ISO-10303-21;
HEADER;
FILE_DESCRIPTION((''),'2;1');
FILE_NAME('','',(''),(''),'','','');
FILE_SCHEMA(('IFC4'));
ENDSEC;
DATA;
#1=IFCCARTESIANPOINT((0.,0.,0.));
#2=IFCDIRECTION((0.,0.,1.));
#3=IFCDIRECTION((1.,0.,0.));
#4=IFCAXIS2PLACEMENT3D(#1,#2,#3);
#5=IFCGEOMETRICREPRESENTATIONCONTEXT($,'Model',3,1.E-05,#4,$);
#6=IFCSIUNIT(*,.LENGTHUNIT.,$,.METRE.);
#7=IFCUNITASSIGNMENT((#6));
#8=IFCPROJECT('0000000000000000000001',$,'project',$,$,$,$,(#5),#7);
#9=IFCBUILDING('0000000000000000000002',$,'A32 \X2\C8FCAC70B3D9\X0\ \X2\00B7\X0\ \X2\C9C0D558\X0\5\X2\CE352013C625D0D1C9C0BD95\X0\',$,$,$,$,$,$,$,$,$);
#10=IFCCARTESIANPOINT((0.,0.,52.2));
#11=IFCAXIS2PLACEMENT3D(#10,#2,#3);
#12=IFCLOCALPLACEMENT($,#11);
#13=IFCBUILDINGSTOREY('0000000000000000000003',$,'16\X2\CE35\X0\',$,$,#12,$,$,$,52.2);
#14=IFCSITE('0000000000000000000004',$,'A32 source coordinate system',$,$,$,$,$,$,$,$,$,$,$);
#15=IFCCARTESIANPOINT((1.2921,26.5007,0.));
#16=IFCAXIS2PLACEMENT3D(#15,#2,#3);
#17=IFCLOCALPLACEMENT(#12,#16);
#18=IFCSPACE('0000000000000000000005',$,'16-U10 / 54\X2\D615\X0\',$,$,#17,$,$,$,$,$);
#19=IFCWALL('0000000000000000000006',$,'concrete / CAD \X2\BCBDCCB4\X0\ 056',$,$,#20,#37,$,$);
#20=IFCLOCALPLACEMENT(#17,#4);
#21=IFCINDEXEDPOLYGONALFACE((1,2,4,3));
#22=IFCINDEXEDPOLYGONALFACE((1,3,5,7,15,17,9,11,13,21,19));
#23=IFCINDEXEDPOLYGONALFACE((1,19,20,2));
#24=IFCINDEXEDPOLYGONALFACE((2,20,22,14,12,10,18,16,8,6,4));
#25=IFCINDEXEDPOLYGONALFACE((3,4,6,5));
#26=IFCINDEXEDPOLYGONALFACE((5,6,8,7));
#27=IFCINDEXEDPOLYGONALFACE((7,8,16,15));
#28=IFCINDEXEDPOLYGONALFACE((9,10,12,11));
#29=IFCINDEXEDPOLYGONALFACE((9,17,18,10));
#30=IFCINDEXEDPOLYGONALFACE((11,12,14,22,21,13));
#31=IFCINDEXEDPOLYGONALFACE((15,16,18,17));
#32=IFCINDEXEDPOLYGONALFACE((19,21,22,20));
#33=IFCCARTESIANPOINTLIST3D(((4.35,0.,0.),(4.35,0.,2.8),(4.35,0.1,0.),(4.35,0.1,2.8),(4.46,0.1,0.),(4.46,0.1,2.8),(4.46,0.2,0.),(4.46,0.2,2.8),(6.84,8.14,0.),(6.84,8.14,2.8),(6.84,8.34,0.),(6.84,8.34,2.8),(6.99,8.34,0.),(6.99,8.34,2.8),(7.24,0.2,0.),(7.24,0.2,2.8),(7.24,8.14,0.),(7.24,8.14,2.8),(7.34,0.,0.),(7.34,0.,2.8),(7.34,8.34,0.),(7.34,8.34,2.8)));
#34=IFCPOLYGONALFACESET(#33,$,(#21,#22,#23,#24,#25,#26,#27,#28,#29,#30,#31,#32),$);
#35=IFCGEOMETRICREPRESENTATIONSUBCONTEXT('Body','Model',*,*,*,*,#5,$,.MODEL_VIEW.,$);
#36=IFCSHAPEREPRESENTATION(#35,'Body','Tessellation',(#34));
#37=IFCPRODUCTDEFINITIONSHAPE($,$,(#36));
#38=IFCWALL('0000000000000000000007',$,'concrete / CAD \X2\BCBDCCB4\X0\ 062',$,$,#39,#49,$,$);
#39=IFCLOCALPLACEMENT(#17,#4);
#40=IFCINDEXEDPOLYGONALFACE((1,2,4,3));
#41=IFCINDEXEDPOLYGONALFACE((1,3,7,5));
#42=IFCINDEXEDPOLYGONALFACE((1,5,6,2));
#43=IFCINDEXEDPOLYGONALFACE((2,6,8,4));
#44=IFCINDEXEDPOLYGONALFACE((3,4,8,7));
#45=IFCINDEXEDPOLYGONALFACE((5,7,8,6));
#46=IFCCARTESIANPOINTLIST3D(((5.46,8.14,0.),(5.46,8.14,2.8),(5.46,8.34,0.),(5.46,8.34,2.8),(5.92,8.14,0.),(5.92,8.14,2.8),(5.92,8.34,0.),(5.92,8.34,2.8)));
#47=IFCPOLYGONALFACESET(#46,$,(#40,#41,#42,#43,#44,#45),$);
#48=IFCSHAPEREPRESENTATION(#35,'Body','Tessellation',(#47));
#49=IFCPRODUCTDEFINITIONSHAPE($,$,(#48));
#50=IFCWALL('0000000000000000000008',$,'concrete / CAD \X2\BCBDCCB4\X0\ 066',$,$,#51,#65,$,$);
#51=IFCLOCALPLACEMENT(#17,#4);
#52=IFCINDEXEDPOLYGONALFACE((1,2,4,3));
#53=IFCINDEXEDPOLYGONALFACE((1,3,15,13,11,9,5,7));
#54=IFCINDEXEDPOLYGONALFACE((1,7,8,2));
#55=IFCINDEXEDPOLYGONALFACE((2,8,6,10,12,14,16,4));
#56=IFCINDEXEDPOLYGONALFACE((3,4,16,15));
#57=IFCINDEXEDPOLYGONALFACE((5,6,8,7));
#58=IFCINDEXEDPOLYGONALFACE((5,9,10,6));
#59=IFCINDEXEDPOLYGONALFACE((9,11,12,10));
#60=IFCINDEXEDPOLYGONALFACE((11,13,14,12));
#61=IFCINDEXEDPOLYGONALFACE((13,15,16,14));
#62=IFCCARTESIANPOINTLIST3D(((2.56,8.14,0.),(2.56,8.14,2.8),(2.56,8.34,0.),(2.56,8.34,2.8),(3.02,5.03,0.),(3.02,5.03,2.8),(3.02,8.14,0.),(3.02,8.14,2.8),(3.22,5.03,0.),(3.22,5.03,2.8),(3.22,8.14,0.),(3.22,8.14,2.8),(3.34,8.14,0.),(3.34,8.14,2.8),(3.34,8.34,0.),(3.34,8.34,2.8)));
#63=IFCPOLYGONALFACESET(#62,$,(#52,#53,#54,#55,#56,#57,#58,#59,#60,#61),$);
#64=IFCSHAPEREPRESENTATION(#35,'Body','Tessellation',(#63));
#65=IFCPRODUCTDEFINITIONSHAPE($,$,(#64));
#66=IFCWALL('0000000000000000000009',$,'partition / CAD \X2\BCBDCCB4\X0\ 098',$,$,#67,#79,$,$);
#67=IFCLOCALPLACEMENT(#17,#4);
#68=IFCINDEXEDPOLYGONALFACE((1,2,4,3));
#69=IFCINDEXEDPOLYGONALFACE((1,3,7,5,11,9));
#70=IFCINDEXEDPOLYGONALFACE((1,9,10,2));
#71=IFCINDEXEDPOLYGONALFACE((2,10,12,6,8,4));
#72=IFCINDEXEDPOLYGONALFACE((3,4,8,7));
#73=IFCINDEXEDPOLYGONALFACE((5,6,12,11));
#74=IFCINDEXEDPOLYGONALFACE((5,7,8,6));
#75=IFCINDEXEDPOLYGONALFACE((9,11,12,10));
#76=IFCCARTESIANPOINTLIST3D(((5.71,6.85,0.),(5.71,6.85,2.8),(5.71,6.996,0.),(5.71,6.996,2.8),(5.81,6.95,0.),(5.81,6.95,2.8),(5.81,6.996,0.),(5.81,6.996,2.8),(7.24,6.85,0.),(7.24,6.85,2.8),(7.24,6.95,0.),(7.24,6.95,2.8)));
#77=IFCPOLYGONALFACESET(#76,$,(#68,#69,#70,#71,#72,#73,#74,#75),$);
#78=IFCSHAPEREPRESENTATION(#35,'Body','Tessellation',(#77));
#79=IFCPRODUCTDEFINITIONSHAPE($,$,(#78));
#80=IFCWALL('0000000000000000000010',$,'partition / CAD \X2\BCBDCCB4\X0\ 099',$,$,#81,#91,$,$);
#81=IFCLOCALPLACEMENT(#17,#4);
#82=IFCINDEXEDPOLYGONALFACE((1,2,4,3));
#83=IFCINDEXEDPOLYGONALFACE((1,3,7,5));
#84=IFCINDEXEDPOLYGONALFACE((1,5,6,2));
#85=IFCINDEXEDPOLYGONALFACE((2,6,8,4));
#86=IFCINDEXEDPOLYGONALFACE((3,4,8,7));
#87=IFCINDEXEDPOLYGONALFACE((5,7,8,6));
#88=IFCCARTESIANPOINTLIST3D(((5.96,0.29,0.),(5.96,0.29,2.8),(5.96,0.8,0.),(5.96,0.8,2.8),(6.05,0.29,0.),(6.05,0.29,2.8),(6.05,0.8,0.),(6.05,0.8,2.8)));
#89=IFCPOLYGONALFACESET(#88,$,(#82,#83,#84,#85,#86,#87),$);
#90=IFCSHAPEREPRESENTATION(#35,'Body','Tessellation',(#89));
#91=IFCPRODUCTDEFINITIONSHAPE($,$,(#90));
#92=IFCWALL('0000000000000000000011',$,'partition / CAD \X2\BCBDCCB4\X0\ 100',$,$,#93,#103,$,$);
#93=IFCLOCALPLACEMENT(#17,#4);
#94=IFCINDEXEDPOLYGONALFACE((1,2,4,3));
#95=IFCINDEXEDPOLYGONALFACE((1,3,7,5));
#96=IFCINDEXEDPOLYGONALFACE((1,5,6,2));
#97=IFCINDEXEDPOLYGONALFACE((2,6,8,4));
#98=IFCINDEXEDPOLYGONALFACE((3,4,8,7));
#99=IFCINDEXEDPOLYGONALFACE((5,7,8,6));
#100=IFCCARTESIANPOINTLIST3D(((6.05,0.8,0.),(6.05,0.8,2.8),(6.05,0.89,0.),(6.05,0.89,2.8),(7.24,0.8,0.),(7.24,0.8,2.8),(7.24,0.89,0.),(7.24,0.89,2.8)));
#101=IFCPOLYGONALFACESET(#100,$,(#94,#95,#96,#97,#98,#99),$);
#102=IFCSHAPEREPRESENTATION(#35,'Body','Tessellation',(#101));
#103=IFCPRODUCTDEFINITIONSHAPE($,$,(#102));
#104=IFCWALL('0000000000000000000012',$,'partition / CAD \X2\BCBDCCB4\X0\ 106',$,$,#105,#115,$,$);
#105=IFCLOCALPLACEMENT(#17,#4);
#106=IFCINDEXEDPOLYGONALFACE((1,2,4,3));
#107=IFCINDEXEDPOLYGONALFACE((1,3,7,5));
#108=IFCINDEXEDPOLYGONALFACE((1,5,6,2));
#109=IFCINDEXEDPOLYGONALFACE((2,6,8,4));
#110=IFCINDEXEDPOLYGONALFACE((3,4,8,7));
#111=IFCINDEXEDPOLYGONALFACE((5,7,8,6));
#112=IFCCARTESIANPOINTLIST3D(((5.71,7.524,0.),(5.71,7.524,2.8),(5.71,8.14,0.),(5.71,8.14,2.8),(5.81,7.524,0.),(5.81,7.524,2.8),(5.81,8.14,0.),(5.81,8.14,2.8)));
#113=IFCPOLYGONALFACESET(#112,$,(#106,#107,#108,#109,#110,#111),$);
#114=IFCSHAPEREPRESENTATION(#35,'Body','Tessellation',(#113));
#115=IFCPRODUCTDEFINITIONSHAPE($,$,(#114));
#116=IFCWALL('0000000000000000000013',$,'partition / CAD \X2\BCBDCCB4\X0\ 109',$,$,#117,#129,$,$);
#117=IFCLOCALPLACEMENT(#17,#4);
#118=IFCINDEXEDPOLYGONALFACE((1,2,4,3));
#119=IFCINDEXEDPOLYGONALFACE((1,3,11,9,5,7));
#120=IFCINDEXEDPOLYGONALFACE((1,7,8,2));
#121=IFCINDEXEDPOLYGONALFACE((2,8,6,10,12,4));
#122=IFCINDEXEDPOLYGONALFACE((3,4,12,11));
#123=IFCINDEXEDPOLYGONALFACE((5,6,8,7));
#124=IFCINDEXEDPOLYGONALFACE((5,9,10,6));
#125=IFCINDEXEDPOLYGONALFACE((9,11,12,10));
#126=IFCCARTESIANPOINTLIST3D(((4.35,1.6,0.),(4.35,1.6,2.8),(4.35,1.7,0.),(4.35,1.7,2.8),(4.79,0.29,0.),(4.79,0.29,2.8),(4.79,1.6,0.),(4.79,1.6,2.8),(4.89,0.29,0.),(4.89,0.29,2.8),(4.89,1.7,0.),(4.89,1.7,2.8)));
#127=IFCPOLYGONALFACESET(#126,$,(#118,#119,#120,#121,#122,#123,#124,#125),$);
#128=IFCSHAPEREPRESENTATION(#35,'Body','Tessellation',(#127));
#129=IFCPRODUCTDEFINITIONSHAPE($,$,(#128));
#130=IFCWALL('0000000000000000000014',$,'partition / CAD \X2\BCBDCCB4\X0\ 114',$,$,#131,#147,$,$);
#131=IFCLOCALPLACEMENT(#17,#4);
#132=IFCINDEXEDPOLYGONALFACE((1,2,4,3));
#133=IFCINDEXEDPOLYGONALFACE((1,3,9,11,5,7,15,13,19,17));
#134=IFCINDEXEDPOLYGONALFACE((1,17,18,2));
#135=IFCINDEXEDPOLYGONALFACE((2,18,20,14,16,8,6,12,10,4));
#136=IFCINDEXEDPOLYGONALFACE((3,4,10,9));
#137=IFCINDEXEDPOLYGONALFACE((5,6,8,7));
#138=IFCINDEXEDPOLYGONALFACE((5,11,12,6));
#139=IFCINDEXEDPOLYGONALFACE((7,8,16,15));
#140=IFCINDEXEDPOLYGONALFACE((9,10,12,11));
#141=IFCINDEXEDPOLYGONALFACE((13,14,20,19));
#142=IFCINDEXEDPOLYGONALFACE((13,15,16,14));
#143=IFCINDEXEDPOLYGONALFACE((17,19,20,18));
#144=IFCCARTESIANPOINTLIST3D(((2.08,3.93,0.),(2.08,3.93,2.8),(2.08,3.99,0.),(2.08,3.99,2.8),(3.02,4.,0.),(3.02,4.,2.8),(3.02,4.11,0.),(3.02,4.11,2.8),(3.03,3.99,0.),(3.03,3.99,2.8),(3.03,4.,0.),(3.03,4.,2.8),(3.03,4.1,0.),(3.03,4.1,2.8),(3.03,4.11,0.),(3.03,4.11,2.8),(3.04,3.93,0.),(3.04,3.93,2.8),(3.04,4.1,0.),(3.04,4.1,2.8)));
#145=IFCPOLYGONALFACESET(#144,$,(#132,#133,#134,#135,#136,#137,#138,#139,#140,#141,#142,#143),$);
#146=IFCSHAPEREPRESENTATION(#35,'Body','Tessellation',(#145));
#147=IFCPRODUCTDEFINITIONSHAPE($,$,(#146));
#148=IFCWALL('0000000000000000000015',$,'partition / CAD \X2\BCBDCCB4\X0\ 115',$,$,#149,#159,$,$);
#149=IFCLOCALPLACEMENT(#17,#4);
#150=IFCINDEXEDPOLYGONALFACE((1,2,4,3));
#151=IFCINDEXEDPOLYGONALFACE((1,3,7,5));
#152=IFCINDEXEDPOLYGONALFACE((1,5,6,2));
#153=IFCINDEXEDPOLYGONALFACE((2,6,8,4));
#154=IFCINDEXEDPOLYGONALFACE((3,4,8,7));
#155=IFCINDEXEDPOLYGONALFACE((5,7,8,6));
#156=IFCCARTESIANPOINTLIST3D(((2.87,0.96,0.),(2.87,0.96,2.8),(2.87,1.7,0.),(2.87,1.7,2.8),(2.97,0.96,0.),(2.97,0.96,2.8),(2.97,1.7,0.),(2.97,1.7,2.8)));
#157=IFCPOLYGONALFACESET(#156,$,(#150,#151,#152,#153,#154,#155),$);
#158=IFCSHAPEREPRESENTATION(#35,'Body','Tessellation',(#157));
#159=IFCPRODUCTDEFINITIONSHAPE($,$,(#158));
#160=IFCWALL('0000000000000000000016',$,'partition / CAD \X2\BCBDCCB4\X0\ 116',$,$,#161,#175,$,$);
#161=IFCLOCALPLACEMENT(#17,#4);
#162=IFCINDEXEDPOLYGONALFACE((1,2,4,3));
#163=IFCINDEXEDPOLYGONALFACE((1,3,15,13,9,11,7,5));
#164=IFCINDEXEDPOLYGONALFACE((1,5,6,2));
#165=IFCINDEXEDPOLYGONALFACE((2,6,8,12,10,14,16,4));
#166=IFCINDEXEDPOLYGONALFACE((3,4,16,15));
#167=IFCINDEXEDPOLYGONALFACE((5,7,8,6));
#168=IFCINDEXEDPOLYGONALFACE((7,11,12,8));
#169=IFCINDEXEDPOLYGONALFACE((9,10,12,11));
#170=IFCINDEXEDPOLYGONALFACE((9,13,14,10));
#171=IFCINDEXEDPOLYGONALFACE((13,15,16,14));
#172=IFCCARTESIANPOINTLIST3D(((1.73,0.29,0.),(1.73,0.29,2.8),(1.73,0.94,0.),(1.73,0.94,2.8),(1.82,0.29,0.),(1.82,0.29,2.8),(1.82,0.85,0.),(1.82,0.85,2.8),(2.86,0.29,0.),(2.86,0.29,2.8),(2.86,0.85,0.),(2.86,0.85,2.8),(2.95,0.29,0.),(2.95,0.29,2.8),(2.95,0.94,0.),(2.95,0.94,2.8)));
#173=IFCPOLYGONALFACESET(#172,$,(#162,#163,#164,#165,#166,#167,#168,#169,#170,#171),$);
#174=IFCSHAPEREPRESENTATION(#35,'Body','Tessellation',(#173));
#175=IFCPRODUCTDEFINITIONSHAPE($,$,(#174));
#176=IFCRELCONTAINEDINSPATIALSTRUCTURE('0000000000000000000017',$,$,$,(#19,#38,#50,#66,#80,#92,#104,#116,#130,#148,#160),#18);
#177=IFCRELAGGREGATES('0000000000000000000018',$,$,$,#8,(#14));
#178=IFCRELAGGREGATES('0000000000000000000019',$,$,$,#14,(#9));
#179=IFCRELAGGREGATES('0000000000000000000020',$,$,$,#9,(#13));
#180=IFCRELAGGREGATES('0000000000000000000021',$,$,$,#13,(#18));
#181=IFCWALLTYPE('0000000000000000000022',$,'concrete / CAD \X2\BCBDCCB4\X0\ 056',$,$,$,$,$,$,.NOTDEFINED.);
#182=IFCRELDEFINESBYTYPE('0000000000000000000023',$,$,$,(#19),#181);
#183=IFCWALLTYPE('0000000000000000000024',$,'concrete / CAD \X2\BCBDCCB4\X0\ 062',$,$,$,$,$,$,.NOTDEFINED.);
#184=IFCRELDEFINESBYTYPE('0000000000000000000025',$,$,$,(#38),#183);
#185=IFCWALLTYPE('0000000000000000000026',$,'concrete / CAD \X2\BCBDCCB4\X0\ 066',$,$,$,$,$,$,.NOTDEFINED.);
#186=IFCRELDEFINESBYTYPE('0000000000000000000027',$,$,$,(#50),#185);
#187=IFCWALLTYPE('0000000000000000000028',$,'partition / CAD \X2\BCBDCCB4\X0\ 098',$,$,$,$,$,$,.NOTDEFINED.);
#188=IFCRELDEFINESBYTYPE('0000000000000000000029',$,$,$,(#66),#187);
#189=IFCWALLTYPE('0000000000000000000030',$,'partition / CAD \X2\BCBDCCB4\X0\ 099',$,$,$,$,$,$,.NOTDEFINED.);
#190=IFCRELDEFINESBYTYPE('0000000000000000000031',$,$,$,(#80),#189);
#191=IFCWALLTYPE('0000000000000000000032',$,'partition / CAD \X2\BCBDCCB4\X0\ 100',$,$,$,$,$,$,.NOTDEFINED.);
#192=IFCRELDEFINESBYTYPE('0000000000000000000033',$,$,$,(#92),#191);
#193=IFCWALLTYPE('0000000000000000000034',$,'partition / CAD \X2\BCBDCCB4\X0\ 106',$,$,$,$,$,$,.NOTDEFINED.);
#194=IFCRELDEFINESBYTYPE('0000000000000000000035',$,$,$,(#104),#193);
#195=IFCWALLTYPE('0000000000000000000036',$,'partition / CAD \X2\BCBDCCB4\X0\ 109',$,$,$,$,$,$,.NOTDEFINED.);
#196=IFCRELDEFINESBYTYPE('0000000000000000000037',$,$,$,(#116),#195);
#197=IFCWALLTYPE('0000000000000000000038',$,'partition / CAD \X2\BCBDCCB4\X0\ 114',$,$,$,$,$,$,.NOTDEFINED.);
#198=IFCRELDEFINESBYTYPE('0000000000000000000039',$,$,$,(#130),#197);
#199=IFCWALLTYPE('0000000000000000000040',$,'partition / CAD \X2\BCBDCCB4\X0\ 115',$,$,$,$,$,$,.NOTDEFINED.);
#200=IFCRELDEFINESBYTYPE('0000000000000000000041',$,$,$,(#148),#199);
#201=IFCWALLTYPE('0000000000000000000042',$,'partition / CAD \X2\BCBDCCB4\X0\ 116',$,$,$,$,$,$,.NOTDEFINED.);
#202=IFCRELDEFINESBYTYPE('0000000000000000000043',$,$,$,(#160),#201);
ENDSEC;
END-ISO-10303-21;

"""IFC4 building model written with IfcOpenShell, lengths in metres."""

from ifc_helpers import new_model, si_unit, frame, origin, origin_with_axes, place, context, subcontext, project, spatial, polyline, outline, extrude, source, transform, mapped, type_object, type_shapes, element, save


model = new_model("IFC4")

# Units and contexts
model_context = context("Model", 3, precision=1e-05, world=origin_with_axes())
body_context = subcontext(model_context, "Body", "Model", "MODEL_VIEW")
ifc_project = project(units=[si_unit("LENGTHUNIT", "METRE")], contexts=[model_context])

# Site, building, storey, space
site = spatial("IfcSite", under=ifc_project, Name="A32 source coordinate system")
building = spatial("IfcBuilding", under=site, Name="A32 주거동 · 지하5층–옥탑지붕")
storey_placement = place(None, frame((0.0, 0.0, 52.2), z_axis=(0.0, 0.0, 1.0), x_axis=(1.0, 0.0, 0.0)))
storey = spatial("IfcBuildingStorey", under=building, at=storey_placement, Name="16층", Elevation=52.2)
space_placement = place(storey_placement, frame((1.2921, 26.5007, 0.0), z_axis=(0.0, 0.0, 1.0), x_axis=(1.0, 0.0, 0.0)))
space = spatial("IfcSpace", under=storey, at=space_placement, Name="16-U10 / 54형")

# Walls
wall_type_1 = type_object("IfcWallType", Name="concrete / CAD 벽체 056", PredefinedType="NOTDEFINED")
shared_shape_1 = source(origin(), body_context, "Body", "SweptSolid", [
    extrude(outline(polyline([(7.24, 0.2), (7.24, 8.14), (6.84, 8.14), (6.84, 8.34), (6.99, 8.34), (6.99, 8.34), (7.34, 8.34), (7.34, 0.0), (4.35, 0.0), (4.35, 0.1), (4.46, 0.1), (4.46, 0.2), (7.24, 0.2)])), origin(), (0.0, 0.0, 1.0), 2.8),
])
type_shapes(wall_type_1, [shared_shape_1])
wall_1_placement = place(space_placement, origin_with_axes())
element("IfcWall", 1, at=wall_1_placement, inside=space, type_object=wall_type_1, Name="concrete / CAD 벽체 056", context=body_context, shape_type="MappedRepresentation", body=[
    mapped(shared_shape_1, transform((0.0, 0.0, 0.0), scale=1.0)),
])
wall_type_2 = type_object("IfcWallType", Name="concrete / CAD 벽체 062", PredefinedType="NOTDEFINED")
shared_shape_2 = source(origin(), body_context, "Body", "SweptSolid", [
    extrude(outline(polyline([(5.46, 8.14), (5.46, 8.34), (5.92, 8.34), (5.92, 8.14), (5.46, 8.14)])), origin(), (0.0, 0.0, 1.0), 2.8),
])
type_shapes(wall_type_2, [shared_shape_2])
wall_2_placement = place(space_placement, origin_with_axes())
element("IfcWall", 2, at=wall_2_placement, inside=space, type_object=wall_type_2, Name="concrete / CAD 벽체 062", context=body_context, shape_type="MappedRepresentation", body=[
    mapped(shared_shape_2, transform((0.0, 0.0, 0.0), scale=1.0)),
])
wall_type_3 = type_object("IfcWallType", Name="concrete / CAD 벽체 066", PredefinedType="NOTDEFINED")
shared_shape_3 = source(origin(), body_context, "Body", "SweptSolid", [
    extrude(outline(polyline([(3.22, 8.14), (3.22, 5.03), (3.02, 5.03), (3.02, 8.14), (2.56, 8.14), (2.56, 8.34), (3.34, 8.34), (3.34, 8.14), (3.22, 8.14)])), origin(), (0.0, 0.0, 1.0), 2.8),
])
type_shapes(wall_type_3, [shared_shape_3])
wall_3_placement = place(space_placement, origin_with_axes())
element("IfcWall", 3, at=wall_3_placement, inside=space, type_object=wall_type_3, Name="concrete / CAD 벽체 066", context=body_context, shape_type="MappedRepresentation", body=[
    mapped(shared_shape_3, transform((0.0, 0.0, 0.0), scale=1.0)),
])
wall_type_4 = type_object("IfcWallType", Name="partition / CAD 벽체 098", PredefinedType="NOTDEFINED")
shared_shape_4 = source(origin(), body_context, "Body", "SweptSolid", [
    extrude(outline(polyline([(5.71, 6.996), (5.81, 6.996), (5.81, 6.95), (7.24, 6.95), (7.24, 6.85), (5.71, 6.85), (5.71, 6.996)])), origin(), (0.0, 0.0, 1.0), 2.8),
])
type_shapes(wall_type_4, [shared_shape_4])
wall_4_placement = place(space_placement, origin_with_axes())
element("IfcWall", 4, at=wall_4_placement, inside=space, type_object=wall_type_4, Name="partition / CAD 벽체 098", context=body_context, shape_type="MappedRepresentation", body=[
    mapped(shared_shape_4, transform((0.0, 0.0, 0.0), scale=1.0)),
])
wall_type_5 = type_object("IfcWallType", Name="partition / CAD 벽체 099", PredefinedType="NOTDEFINED")
shared_shape_5 = source(origin(), body_context, "Body", "SweptSolid", [
    extrude(outline(polyline([(6.05, 0.8), (6.05, 0.29), (5.96, 0.29), (5.96, 0.8), (6.05, 0.8)])), origin(), (0.0, 0.0, 1.0), 2.8),
])
type_shapes(wall_type_5, [shared_shape_5])
wall_5_placement = place(space_placement, origin_with_axes())
element("IfcWall", 5, at=wall_5_placement, inside=space, type_object=wall_type_5, Name="partition / CAD 벽체 099", context=body_context, shape_type="MappedRepresentation", body=[
    mapped(shared_shape_5, transform((0.0, 0.0, 0.0), scale=1.0)),
])
wall_type_6 = type_object("IfcWallType", Name="partition / CAD 벽체 100", PredefinedType="NOTDEFINED")
shared_shape_6 = source(origin(), body_context, "Body", "SweptSolid", [
    extrude(outline(polyline([(7.24, 0.8), (6.05, 0.8), (6.05, 0.89), (7.24, 0.89), (7.24, 0.8)])), origin(), (0.0, 0.0, 1.0), 2.8),
])
type_shapes(wall_type_6, [shared_shape_6])
wall_6_placement = place(space_placement, origin_with_axes())
element("IfcWall", 6, at=wall_6_placement, inside=space, type_object=wall_type_6, Name="partition / CAD 벽체 100", context=body_context, shape_type="MappedRepresentation", body=[
    mapped(shared_shape_6, transform((0.0, 0.0, 0.0), scale=1.0)),
])
wall_type_7 = type_object("IfcWallType", Name="partition / CAD 벽체 106", PredefinedType="NOTDEFINED")
shared_shape_7 = source(origin(), body_context, "Body", "SweptSolid", [
    extrude(outline(polyline([(5.71, 8.14), (5.81, 8.14), (5.81, 7.524), (5.71, 7.524), (5.71, 8.14)])), origin(), (0.0, 0.0, 1.0), 2.8),
])
type_shapes(wall_type_7, [shared_shape_7])
wall_7_placement = place(space_placement, origin_with_axes())
element("IfcWall", 7, at=wall_7_placement, inside=space, type_object=wall_type_7, Name="partition / CAD 벽체 106", context=body_context, shape_type="MappedRepresentation", body=[
    mapped(shared_shape_7, transform((0.0, 0.0, 0.0), scale=1.0)),
])
wall_type_8 = type_object("IfcWallType", Name="partition / CAD 벽체 109", PredefinedType="NOTDEFINED")
shared_shape_8 = source(origin(), body_context, "Body", "SweptSolid", [
    extrude(outline(polyline([(4.79, 1.6), (4.35, 1.6), (4.35, 1.7), (4.89, 1.7), (4.89, 0.29), (4.79, 0.29), (4.79, 1.6)])), origin(), (0.0, 0.0, 1.0), 2.8),
])
type_shapes(wall_type_8, [shared_shape_8])
wall_8_placement = place(space_placement, origin_with_axes())
element("IfcWall", 8, at=wall_8_placement, inside=space, type_object=wall_type_8, Name="partition / CAD 벽체 109", context=body_context, shape_type="MappedRepresentation", body=[
    mapped(shared_shape_8, transform((0.0, 0.0, 0.0), scale=1.0)),
])
wall_type_9 = type_object("IfcWallType", Name="partition / CAD 벽체 114", PredefinedType="NOTDEFINED")
shared_shape_9 = source(origin(), body_context, "Body", "SweptSolid", [
    extrude(outline(polyline([(2.08, 3.99), (3.03, 3.99), (3.03, 4.0), (3.02, 4.0), (3.02, 4.11), (3.03, 4.11), (3.03, 4.1), (3.04, 4.1), (3.04, 3.93), (2.08, 3.93), (2.08, 3.99)])), origin(), (0.0, 0.0, 1.0), 2.8),
])
type_shapes(wall_type_9, [shared_shape_9])
wall_9_placement = place(space_placement, origin_with_axes())
element("IfcWall", 9, at=wall_9_placement, inside=space, type_object=wall_type_9, Name="partition / CAD 벽체 114", context=body_context, shape_type="MappedRepresentation", body=[
    mapped(shared_shape_9, transform((0.0, 0.0, 0.0), scale=1.0)),
])
wall_type_10 = type_object("IfcWallType", Name="partition / CAD 벽체 115", PredefinedType="NOTDEFINED")
shared_shape_10 = source(origin(), body_context, "Body", "SweptSolid", [
    extrude(outline(polyline([(2.87, 1.7), (2.97, 1.7), (2.97, 0.96), (2.87, 0.96), (2.87, 1.7)])), origin(), (0.0, 0.0, 1.0), 2.8),
])
type_shapes(wall_type_10, [shared_shape_10])
wall_10_placement = place(space_placement, origin_with_axes())
element("IfcWall", 10, at=wall_10_placement, inside=space, type_object=wall_type_10, Name="partition / CAD 벽체 115", context=body_context, shape_type="MappedRepresentation", body=[
    mapped(shared_shape_10, transform((0.0, 0.0, 0.0), scale=1.0)),
])
wall_type_11 = type_object("IfcWallType", Name="partition / CAD 벽체 116", PredefinedType="NOTDEFINED")
shared_shape_11 = source(origin(), body_context, "Body", "SweptSolid", [
    extrude(outline(polyline([(2.95, 0.29), (2.86, 0.29), (2.86, 0.85), (1.82, 0.85), (1.82, 0.29), (1.73, 0.29), (1.73, 0.94), (2.95, 0.94), (2.95, 0.29)])), origin(), (0.0, 0.0, 1.0), 2.8),
])
type_shapes(wall_type_11, [shared_shape_11])
wall_11_placement = place(space_placement, origin_with_axes())
element("IfcWall", 11, at=wall_11_placement, inside=space, type_object=wall_type_11, Name="partition / CAD 벽체 116", context=body_context, shape_type="MappedRepresentation", body=[
    mapped(shared_shape_11, transform((0.0, 0.0, 0.0), scale=1.0)),
])

save(model, "model.ifc")
